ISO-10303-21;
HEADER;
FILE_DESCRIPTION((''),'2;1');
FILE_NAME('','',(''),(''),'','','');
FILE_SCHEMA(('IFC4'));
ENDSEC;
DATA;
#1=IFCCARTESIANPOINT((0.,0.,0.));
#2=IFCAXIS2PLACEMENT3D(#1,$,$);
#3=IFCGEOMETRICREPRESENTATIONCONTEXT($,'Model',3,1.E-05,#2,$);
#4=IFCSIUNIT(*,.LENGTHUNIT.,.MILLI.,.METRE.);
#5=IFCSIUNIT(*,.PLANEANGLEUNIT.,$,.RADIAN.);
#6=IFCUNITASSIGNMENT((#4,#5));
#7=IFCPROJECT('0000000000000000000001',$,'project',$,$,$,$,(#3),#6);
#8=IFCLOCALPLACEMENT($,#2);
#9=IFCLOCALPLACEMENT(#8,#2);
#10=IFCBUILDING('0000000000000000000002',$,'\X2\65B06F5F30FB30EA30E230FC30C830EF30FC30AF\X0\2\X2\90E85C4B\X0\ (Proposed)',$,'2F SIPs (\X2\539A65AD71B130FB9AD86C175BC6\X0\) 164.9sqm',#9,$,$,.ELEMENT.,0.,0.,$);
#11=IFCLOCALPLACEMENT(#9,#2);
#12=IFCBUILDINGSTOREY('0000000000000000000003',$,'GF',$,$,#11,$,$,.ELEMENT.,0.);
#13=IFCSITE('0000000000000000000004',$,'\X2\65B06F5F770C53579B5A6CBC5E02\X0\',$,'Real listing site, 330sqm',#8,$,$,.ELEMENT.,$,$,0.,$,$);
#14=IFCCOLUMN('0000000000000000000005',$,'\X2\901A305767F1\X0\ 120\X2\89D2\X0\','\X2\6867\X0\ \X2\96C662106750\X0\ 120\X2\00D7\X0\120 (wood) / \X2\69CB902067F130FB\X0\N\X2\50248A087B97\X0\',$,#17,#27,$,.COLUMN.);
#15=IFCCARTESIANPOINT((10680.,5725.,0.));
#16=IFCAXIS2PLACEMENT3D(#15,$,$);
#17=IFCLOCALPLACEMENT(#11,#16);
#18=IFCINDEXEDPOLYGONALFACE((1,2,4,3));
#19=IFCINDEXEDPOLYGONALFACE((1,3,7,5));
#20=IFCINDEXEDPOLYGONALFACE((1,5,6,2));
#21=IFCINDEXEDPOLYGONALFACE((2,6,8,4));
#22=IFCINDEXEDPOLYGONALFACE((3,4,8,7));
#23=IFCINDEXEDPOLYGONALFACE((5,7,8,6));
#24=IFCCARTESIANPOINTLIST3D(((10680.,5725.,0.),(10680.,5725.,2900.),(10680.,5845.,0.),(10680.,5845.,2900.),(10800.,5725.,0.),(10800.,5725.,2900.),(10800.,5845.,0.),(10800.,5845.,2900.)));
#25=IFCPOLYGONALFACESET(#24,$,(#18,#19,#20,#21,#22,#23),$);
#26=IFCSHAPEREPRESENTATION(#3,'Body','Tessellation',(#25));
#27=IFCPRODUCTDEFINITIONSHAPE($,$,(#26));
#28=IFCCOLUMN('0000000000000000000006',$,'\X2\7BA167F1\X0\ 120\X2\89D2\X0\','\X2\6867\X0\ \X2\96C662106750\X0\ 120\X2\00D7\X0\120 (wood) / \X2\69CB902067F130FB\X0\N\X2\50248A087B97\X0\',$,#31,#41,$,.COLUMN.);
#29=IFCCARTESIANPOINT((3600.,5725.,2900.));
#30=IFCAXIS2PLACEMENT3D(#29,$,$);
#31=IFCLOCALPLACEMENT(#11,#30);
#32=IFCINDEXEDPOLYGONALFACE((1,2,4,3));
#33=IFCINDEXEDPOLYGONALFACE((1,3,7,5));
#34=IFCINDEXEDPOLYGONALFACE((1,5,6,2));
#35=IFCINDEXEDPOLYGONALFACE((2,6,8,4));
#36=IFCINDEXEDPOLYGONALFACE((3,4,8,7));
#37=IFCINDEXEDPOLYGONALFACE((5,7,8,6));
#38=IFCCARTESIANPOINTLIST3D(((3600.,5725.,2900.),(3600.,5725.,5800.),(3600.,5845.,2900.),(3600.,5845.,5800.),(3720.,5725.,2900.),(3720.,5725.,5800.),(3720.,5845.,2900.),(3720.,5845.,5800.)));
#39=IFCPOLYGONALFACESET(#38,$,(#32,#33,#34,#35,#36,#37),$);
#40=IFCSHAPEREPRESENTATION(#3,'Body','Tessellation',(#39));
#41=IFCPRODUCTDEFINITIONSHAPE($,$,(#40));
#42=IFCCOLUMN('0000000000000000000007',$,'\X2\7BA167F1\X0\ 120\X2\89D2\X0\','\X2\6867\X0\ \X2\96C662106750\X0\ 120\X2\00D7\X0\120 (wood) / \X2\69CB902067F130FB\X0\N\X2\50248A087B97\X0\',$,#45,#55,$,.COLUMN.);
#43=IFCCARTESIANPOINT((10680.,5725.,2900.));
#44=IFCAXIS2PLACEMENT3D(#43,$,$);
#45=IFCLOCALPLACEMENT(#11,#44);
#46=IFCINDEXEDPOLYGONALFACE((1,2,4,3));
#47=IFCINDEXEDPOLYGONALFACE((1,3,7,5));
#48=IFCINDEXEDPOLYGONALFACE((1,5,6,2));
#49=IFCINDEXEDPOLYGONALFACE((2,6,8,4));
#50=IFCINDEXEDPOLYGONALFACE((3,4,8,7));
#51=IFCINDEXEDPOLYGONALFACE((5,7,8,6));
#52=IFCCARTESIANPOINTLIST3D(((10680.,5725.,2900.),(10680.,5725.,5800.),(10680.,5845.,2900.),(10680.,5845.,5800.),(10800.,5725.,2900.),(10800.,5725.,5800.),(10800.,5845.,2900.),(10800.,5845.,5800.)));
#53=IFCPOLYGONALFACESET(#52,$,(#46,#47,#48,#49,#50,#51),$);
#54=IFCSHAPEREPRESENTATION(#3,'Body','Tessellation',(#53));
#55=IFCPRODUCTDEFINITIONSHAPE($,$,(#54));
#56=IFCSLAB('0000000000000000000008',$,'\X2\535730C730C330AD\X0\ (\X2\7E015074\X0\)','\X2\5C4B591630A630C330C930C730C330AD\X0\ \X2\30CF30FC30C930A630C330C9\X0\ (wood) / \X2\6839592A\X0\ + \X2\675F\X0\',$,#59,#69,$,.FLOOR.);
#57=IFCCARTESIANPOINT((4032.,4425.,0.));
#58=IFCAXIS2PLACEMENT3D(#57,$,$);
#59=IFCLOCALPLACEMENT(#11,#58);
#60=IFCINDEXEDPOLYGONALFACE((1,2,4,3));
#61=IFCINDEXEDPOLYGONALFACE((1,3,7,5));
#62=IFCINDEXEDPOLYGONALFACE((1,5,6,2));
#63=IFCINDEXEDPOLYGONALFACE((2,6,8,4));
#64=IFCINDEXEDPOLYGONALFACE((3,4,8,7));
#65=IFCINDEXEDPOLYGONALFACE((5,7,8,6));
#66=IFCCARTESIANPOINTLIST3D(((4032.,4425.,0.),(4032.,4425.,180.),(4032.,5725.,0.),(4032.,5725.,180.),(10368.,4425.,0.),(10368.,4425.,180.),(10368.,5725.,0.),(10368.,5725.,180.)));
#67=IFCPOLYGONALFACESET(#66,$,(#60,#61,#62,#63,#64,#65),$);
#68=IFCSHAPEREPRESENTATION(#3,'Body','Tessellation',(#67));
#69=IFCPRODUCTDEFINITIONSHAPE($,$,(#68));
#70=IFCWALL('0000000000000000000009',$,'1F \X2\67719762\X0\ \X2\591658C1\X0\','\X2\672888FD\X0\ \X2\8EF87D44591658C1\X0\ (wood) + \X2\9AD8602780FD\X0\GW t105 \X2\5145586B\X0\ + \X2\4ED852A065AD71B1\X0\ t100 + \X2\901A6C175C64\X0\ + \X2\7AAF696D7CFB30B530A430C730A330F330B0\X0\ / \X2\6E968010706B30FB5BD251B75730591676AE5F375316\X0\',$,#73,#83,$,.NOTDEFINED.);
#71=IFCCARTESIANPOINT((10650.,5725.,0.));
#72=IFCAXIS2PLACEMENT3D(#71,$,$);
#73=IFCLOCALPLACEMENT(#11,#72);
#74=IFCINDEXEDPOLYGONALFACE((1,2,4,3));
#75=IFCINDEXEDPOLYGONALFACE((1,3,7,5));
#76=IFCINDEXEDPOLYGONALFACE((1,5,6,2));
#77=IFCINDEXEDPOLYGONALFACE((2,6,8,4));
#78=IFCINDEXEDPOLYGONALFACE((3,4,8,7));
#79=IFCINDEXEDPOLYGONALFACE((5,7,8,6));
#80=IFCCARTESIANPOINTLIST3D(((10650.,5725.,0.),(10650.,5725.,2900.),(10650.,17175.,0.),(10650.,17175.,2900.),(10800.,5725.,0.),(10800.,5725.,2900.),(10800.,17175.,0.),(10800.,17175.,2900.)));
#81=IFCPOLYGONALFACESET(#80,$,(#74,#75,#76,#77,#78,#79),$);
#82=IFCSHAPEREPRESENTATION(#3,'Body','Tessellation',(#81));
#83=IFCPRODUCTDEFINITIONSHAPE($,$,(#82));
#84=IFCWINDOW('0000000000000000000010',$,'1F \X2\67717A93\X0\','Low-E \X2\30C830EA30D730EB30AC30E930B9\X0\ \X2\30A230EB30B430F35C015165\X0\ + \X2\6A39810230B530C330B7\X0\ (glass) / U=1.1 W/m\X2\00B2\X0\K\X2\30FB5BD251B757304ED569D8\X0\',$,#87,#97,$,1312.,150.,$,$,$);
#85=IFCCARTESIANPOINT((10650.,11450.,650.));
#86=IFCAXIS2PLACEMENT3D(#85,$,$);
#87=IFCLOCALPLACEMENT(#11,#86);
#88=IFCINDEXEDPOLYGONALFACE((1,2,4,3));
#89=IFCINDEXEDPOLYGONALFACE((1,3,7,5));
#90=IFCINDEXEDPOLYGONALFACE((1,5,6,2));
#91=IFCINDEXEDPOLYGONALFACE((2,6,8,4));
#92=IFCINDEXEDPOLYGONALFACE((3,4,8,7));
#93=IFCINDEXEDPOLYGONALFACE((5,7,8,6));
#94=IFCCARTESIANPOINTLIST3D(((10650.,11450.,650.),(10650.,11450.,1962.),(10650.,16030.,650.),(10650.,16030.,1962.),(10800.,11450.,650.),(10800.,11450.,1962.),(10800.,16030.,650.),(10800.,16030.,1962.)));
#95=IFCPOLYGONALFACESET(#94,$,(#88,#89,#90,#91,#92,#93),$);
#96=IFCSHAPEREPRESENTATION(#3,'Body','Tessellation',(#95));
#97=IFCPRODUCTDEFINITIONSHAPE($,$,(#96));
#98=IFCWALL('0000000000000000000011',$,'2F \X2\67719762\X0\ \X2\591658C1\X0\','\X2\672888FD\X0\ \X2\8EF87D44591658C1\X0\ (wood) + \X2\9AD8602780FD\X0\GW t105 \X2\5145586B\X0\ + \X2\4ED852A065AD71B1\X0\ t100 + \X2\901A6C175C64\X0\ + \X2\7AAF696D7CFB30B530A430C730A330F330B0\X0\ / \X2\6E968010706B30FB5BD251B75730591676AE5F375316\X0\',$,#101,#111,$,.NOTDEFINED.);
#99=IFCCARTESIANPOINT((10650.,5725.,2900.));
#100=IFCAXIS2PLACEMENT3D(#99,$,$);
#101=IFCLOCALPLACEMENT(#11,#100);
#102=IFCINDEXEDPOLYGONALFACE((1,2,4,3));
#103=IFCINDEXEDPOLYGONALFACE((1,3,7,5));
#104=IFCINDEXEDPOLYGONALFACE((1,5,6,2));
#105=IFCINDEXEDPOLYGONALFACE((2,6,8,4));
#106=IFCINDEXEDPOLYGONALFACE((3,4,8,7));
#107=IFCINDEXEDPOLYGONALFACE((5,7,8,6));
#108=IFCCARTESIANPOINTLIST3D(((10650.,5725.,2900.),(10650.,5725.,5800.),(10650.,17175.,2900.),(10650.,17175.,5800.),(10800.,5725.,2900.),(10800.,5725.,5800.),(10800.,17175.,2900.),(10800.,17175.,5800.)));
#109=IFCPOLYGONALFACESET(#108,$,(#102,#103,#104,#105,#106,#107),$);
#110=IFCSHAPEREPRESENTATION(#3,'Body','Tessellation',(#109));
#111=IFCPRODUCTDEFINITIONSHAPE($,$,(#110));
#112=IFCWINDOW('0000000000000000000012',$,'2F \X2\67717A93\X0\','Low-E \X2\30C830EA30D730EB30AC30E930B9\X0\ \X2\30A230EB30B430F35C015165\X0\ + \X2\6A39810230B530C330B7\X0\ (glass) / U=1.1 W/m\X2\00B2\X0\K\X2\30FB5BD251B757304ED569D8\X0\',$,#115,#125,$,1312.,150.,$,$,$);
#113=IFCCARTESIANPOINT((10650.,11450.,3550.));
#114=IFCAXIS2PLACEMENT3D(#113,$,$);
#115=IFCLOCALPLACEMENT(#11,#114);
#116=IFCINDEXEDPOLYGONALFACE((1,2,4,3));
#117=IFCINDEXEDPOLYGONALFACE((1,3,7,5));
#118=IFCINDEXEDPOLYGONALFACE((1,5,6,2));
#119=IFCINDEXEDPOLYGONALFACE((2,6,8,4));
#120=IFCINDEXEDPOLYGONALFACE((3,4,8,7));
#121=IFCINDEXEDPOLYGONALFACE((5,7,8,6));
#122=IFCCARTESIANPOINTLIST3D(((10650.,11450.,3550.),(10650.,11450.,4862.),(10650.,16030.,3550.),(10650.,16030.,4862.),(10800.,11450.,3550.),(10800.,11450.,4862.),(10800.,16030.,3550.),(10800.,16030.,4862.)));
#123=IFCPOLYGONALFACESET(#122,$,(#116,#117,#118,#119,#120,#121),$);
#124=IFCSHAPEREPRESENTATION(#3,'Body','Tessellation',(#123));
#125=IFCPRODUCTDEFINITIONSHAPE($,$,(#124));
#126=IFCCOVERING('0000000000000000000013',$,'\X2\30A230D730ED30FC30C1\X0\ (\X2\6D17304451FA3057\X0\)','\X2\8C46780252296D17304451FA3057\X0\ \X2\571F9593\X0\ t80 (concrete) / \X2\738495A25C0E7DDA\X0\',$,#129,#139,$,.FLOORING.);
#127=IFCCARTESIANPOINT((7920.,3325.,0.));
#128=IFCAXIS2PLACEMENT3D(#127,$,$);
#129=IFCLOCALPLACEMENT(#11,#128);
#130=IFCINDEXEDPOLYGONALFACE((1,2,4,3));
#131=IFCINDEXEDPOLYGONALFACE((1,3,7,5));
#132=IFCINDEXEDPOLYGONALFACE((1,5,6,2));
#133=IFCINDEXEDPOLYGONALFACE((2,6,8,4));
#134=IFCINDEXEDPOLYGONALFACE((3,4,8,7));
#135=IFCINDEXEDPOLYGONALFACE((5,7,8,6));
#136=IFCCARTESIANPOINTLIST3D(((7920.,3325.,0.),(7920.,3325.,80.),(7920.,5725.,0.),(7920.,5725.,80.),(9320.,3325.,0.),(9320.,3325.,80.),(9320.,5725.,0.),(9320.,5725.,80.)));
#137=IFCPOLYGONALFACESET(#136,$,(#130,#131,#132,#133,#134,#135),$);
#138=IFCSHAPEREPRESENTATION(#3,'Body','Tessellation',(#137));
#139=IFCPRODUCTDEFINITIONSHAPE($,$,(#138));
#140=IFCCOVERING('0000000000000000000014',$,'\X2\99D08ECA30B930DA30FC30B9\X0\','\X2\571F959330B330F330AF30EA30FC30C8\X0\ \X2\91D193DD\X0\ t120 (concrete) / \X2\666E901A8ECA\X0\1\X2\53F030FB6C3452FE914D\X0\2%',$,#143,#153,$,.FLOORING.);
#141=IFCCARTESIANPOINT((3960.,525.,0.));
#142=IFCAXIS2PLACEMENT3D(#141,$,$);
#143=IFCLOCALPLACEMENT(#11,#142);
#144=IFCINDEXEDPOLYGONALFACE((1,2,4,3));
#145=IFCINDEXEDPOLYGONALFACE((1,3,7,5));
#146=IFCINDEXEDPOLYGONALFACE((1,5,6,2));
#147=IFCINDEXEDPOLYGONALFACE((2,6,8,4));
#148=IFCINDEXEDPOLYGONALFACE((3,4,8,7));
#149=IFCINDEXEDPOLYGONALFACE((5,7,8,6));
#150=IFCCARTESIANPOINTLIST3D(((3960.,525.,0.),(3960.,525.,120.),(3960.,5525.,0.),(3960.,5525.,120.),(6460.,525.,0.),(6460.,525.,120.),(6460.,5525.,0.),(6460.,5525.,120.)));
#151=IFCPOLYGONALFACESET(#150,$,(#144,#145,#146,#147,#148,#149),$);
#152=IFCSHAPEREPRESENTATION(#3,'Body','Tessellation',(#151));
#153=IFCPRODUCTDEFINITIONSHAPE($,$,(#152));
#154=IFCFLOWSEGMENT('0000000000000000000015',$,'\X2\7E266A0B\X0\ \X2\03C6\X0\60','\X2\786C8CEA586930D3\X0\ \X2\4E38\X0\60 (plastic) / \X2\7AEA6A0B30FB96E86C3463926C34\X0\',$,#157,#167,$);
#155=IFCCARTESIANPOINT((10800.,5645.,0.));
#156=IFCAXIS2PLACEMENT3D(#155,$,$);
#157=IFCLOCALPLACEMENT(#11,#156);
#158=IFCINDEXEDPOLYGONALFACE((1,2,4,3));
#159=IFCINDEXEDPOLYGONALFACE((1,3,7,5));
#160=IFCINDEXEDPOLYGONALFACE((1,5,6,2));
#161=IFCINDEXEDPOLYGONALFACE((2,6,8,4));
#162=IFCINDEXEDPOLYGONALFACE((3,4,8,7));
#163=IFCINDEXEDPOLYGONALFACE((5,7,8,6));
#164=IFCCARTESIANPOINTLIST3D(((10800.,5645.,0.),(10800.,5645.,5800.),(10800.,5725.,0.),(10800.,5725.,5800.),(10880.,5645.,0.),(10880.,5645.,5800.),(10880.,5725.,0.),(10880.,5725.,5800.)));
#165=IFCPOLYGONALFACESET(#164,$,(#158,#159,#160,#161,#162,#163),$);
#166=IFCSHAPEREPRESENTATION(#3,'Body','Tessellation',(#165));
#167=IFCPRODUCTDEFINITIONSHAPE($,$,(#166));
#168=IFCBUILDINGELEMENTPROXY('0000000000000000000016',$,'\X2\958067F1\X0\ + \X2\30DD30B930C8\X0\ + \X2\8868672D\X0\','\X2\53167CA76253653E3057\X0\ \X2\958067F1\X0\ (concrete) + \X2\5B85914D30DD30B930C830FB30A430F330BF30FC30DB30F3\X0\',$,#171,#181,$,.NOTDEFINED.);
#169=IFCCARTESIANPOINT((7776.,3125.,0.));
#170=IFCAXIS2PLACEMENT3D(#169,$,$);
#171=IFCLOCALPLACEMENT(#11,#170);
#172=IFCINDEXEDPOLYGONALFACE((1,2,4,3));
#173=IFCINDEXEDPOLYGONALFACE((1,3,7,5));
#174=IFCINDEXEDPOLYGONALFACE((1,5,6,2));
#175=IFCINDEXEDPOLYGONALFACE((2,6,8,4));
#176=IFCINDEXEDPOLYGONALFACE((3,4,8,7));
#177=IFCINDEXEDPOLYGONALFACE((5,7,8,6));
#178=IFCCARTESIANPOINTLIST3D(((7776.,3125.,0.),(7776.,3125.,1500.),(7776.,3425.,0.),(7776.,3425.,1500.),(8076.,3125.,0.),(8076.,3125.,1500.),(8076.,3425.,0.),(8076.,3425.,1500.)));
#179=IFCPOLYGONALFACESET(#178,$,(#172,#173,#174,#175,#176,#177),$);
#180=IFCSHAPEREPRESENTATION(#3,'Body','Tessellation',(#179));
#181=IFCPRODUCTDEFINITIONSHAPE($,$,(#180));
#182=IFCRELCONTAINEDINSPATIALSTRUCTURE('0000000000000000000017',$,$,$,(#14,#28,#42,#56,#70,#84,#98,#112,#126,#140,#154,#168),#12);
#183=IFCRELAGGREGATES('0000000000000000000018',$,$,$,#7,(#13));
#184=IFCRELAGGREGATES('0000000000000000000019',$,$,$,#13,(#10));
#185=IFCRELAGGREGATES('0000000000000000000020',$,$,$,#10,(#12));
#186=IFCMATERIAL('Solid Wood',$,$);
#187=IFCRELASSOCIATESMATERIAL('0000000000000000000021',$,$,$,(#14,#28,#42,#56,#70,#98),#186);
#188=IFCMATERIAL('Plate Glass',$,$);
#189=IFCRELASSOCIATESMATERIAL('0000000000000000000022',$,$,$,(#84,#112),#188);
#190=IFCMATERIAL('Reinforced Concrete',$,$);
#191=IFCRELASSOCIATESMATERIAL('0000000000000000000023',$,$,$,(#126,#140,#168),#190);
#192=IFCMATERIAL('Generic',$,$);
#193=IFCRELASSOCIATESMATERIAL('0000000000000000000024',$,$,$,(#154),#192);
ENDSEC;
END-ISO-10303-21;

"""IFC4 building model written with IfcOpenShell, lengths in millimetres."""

from ifc_helpers import new_model, si_unit, frame, frame_2d, origin, place, context, project, spatial, rectangle, extrude, material, element, fill, save


model = new_model("IFC4")

# Units and contexts
model_context = context("Model", 3, precision=1e-05, world=origin())
ifc_project = project(units=[si_unit("LENGTHUNIT", "METRE", prefix="MILLI"), si_unit("PLANEANGLEUNIT", "RADIAN")], contexts=[model_context])

# Site, building, storey
site_placement = place(None, origin())
site = spatial("IfcSite", under=ifc_project, at=site_placement, Name="新潟県南魚沼市", ObjectType="Real listing site, 330sqm", CompositionType="ELEMENT", RefElevation=0.0)
building_placement = place(site_placement, origin())
building = spatial("IfcBuilding", under=site, at=building_placement, Name="新潟・リモートワーク2部屋 (Proposed)", ObjectType="2F SIPs (厚断熱・高気密) 164.9sqm", CompositionType="ELEMENT", ElevationOfRefHeight=0.0, ElevationOfTerrain=0.0)
storey_placement = place(building_placement, origin())
storey = spatial("IfcBuildingStorey", under=building, at=storey_placement, Name="GF", CompositionType="ELEMENT", Elevation=0.0)

# Columns
ifc_material_1 = material(Name="Solid Wood")
column_1_placement = place(storey_placement, frame((10680.0, 5725.0, 0.0)))
element("IfcColumn", 1, at=column_1_placement, inside=storey, material=ifc_material_1, Name="通し柱 120角", Description="桧 集成材 120×120 (wood) / 構造柱・N値計算", PredefinedType="COLUMN", context=model_context, shape_type="SweptSolid", body=[
    extrude(rectangle(XDim=120.0, YDim=120.0, at=frame_2d((60.0, 60.0))), frame((10680.0, 5725.0, 0.0)), (0.0, 0.0, 1.0), 2900.0),
])
column_2_placement = place(storey_placement, frame((3600.0, 5725.0, 2900.0)))
element("IfcColumn", 2, at=column_2_placement, inside=storey, material=ifc_material_1, Name="管柱 120角", Description="桧 集成材 120×120 (wood) / 構造柱・N値計算", PredefinedType="COLUMN", context=model_context, shape_type="SweptSolid", body=[
    extrude(rectangle(XDim=120.0, YDim=120.0, at=frame_2d((60.0, 60.0))), frame((3600.0, 5725.0, 2900.0)), (0.0, 0.0, 1.0), 2900.0),
])
column_3_placement = place(storey_placement, frame((10680.0, 5725.0, 2900.0)))
element("IfcColumn", 3, at=column_3_placement, inside=storey, material=ifc_material_1, Name="管柱 120角", Description="桧 集成材 120×120 (wood) / 構造柱・N値計算", PredefinedType="COLUMN", context=model_context, shape_type="SweptSolid", body=[
    extrude(rectangle(XDim=120.0, YDim=120.0, at=frame_2d((60.0, 60.0))), frame((10680.0, 5725.0, 2900.0)), (0.0, 0.0, 1.0), 2900.0),
])

# Slab
slab_placement = place(storey_placement, frame((4032.0, 4425.0, 0.0)))
element("IfcSlab", 4, at=slab_placement, inside=storey, material=ifc_material_1, Name="南デッキ (縁側)", Description="屋外ウッドデッキ ハードウッド (wood) / 根太 + 束", PredefinedType="FLOOR", context=model_context, shape_type="SweptSolid", body=[
    extrude(rectangle(XDim=6336.0, YDim=1300.0, at=frame_2d((3168.0, 650.0))), frame((4032.0, 4425.0, 0.0)), (0.0, 0.0, 1.0), 180.0),
])

# Walls, openings, windows
wall_1_placement = place(storey_placement, frame((10650.0, 5725.0, 0.0)))
wall_1 = element("IfcWall", 5, at=wall_1_placement, inside=storey, material=ifc_material_1, Name="1F 東面 外壁", Description="木製 軸組外壁 (wood) + 高性能GW t105 充填 + 付加断熱 t100 + 通気層 + 窯業系サイディング / 準耐火・寒冷地外皮強化", PredefinedType="NOTDEFINED", context=model_context, shape_type="SweptSolid", body=[
    extrude(rectangle(XDim=150.0, YDim=11450.0, at=frame_2d((75.0, 5725.0))), frame((10650.0, 5725.0, 0.0)), (0.0, 0.0, 1.0), 2900.0),
])
opening_1_placement = place(storey_placement, frame((10650.0, 11450.0, 650.0)))
opening_1 = element("IfcOpeningElement", 6, at=opening_1_placement, cuts=wall_1, PredefinedType="NOTDEFINED", context=model_context, shape_type="SweptSolid", body=[
    extrude(rectangle(XDim=150.0, YDim=4580.0, at=frame_2d((75.0, 2290.0))), frame((10650.0, 11450.0, 650.0)), (0.0, 0.0, 1.0), 1312.0),
])
ifc_material_2 = material(Name="Plate Glass")
window_1_placement = place(storey_placement, frame((10650.0, 11450.0, 650.0)))
window_1 = element("IfcWindow", 7, at=window_1_placement, inside=storey, material=ifc_material_2, Name="1F 東窓", Description="Low-E トリプルガラス アルゴン封入 + 樹脂サッシ (glass) / U=1.1 W/m²K・寒冷地仕様", OverallHeight=1312.0, OverallWidth=150.0, context=model_context, shape_type="SweptSolid", body=[
    extrude(rectangle(XDim=150.0, YDim=4580.0, at=frame_2d((75.0, 2290.0))), frame((10650.0, 11450.0, 650.0)), (0.0, 0.0, 1.0), 1312.0),
])
fill(opening_1, window_1)
wall_2_placement = place(storey_placement, frame((10650.0, 5725.0, 2900.0)))
wall_2 = element("IfcWall", 8, at=wall_2_placement, inside=storey, material=ifc_material_1, Name="2F 東面 外壁", Description="木製 軸組外壁 (wood) + 高性能GW t105 充填 + 付加断熱 t100 + 通気層 + 窯業系サイディング / 準耐火・寒冷地外皮強化", PredefinedType="NOTDEFINED", context=model_context, shape_type="SweptSolid", body=[
    extrude(rectangle(XDim=150.0, YDim=11450.0, at=frame_2d((75.0, 5725.0))), frame((10650.0, 5725.0, 2900.0)), (0.0, 0.0, 1.0), 2900.0),
])
opening_2_placement = place(storey_placement, frame((10650.0, 11450.0, 3550.0)))
opening_2 = element("IfcOpeningElement", 9, at=opening_2_placement, cuts=wall_2, PredefinedType="NOTDEFINED", context=model_context, shape_type="SweptSolid", body=[
    extrude(rectangle(XDim=150.0, YDim=4580.0, at=frame_2d((75.0, 2290.0))), frame((10650.0, 11450.0, 3550.0)), (0.0, 0.0, 1.0), 1312.0),
])
window_2_placement = place(storey_placement, frame((10650.0, 11450.0, 3550.0)))
window_2 = element("IfcWindow", 10, at=window_2_placement, inside=storey, material=ifc_material_2, Name="2F 東窓", Description="Low-E トリプルガラス アルゴン封入 + 樹脂サッシ (glass) / U=1.1 W/m²K・寒冷地仕様", OverallHeight=1312.0, OverallWidth=150.0, context=model_context, shape_type="SweptSolid", body=[
    extrude(rectangle(XDim=150.0, YDim=4580.0, at=frame_2d((75.0, 2290.0))), frame((10650.0, 11450.0, 3550.0)), (0.0, 0.0, 1.0), 1312.0),
])
fill(opening_2, window_2)

# Coverings
ifc_material_3 = material(Name="Reinforced Concrete")
covering_1_placement = place(storey_placement, frame((7920.0, 3325.0, 0.0)))
element("IfcCovering", 11, at=covering_1_placement, inside=storey, material=ifc_material_3, Name="アプローチ (洗い出し)", Description="豆砂利洗い出し 土間 t80 (concrete) / 玄関導線", PredefinedType="FLOORING", context=model_context, shape_type="SweptSolid", body=[
    extrude(rectangle(XDim=1400.0, YDim=2400.0, at=frame_2d((700.0, 1200.0))), frame((7920.0, 3325.0, 0.0)), (0.0, 0.0, 1.0), 80.0),
])
covering_2_placement = place(storey_placement, frame((3960.0, 525.0, 0.0)))
element("IfcCovering", 12, at=covering_2_placement, inside=storey, material=ifc_material_3, Name="駐車スペース", Description="土間コンクリート 金鏝 t120 (concrete) / 普通車1台・水勾配2%", PredefinedType="FLOORING", context=model_context, shape_type="SweptSolid", body=[
    extrude(rectangle(XDim=2500.0, YDim=5000.0, at=frame_2d((1250.0, 2500.0))), frame((3960.0, 525.0, 0.0)), (0.0, 0.0, 1.0), 120.0),
])

# Flow segment
ifc_material_4 = material(Name="Generic")
flow_segment_placement = place(storey_placement, frame((10800.0, 5645.0, 0.0)))
element("IfcFlowSegment", 13, at=flow_segment_placement, inside=storey, material=ifc_material_4, Name="縦樋 φ60", Description="硬質塩ビ 丸60 (plastic) / 竪樋・雨水排水", context=model_context, shape_type="SweptSolid", body=[
    extrude(rectangle(XDim=80.0, YDim=80.0, at=frame_2d((40.0, 40.0))), frame((10800.0, 5645.0, 0.0)), (0.0, 0.0, 1.0), 5800.0),
])

# Building element proxy
proxy_placement = place(storey_placement, frame((7776.0, 3125.0, 0.0)))
element("IfcBuildingElementProxy", 14, at=proxy_placement, inside=storey, material=ifc_material_3, Name="門柱 + ポスト + 表札", Description="化粧打放し 門柱 (concrete) + 宅配ポスト・インターホン", PredefinedType="NOTDEFINED", context=model_context, shape_type="SweptSolid", body=[
    extrude(rectangle(XDim=300.0, YDim=300.0, at=frame_2d((150.0, 150.0))), frame((7776.0, 3125.0, 0.0)), (0.0, 0.0, 1.0), 1500.0),
])

save(model, "model.ifc")
